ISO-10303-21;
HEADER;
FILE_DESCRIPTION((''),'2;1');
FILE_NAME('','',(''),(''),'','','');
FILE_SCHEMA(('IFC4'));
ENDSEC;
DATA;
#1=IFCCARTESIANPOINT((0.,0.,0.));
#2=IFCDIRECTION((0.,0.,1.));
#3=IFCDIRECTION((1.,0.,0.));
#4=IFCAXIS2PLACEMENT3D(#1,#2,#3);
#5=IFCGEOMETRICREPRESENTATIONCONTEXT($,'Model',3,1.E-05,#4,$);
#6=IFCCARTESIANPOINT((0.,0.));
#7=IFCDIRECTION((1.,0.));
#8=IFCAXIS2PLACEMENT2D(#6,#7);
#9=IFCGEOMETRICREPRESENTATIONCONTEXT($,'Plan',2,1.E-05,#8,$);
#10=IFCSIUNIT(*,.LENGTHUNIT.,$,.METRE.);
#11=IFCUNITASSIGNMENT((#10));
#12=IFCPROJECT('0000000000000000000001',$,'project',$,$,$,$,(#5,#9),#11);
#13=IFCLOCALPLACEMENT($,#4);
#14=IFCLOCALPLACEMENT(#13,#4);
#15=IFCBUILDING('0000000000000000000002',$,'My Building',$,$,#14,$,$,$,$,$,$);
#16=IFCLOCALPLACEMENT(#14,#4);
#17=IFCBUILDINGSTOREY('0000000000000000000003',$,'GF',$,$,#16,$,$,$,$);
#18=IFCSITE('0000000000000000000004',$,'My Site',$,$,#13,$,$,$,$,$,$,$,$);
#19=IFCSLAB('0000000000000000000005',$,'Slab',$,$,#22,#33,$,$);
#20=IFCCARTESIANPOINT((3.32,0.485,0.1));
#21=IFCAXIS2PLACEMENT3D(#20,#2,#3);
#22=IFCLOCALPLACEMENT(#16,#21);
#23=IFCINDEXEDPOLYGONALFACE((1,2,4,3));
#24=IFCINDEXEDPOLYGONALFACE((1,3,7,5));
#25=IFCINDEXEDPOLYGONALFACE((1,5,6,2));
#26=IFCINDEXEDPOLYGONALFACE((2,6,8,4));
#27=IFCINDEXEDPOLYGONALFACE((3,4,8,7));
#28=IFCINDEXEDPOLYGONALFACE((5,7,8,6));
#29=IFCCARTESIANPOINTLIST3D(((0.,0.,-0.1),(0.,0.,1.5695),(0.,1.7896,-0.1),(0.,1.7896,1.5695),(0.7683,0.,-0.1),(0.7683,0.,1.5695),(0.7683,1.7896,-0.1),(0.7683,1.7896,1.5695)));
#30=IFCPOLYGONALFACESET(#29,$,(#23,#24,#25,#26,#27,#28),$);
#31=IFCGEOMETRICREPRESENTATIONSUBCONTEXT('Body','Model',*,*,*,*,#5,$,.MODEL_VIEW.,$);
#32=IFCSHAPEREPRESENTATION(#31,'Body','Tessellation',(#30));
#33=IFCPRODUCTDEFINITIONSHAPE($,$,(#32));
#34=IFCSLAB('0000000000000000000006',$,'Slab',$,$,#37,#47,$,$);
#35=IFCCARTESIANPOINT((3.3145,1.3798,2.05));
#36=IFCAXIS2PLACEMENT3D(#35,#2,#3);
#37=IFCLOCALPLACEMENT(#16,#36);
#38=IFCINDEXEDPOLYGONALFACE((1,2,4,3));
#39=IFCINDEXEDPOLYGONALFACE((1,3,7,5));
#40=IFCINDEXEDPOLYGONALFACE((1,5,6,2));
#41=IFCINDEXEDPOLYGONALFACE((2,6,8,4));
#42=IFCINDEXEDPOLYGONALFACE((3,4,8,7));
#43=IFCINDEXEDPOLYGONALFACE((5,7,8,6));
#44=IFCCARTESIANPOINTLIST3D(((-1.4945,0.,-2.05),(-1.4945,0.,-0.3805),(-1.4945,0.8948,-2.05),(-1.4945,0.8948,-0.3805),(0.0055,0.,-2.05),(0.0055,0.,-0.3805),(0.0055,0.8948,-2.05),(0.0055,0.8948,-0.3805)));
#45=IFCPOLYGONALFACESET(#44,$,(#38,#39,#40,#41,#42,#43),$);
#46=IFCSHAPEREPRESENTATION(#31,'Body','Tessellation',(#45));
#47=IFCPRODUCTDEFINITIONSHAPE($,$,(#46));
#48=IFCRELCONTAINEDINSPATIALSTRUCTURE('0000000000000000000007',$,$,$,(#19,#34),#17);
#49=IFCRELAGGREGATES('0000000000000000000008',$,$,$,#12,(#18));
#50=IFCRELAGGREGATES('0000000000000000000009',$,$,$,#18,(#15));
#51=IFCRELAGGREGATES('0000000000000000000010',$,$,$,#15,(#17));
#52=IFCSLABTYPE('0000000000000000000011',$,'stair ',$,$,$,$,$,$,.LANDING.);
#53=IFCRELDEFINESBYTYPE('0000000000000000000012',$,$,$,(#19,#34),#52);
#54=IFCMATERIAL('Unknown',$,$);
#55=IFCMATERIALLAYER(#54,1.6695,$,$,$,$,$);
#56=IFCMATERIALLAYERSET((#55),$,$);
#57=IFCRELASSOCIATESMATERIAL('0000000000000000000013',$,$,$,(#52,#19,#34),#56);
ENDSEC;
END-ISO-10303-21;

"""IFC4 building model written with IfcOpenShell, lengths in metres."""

from ifc_helpers import new_model, si_unit, frame, origin_with_axes, origin_2d_with_axis, place, context, subcontext, project, spatial, indexed_curve, outline, extrude, material, layer, layer_set, layer_usage, type_object, element, save


model = new_model("IFC4")

# Units and contexts
model_context = context("Model", 3, precision=1e-05, world=origin_with_axes())
plan_context = context("Plan", 2, precision=1e-05, world=origin_2d_with_axis())
body_context_1 = subcontext(model_context, "Body", "Model", "MODEL_VIEW")
ifc_project = project(units=[si_unit("LENGTHUNIT", "METRE")], contexts=[model_context, plan_context])

# Site, building, storey
site_placement = place(None, origin_with_axes())
site = spatial("IfcSite", under=ifc_project, at=site_placement, Name="My Site")
building_placement = place(site_placement, origin_with_axes())
building = spatial("IfcBuilding", under=site, at=building_placement, Name="My Building")
storey_placement = place(building_placement, origin_with_axes())
storey = spatial("IfcBuildingStorey", under=building, at=storey_placement, Name="GF")

# Slabs
ifc_material = material(Name="Unknown")
ifc_layer_1 = layer(ifc_material, 1.6695)
ifc_layer_set_1 = layer_set([ifc_layer_1])
ifc_layer_usage_1 = layer_usage(ifc_layer_set_1, "AXIS3", "POSITIVE", -0.1)
slab_type_1 = type_object("IfcSlabType", Name="stair ", PredefinedType="LANDING", material=ifc_layer_set_1)
slab_1_placement = place(storey_placement, frame((3.32, 0.485, 0.1), z_axis=(0.0, 0.0, 1.0), x_axis=(1.0, 0.0, 0.0)))
element("IfcSlab", 1, at=slab_1_placement, inside=storey, type_object=slab_type_1, material=ifc_layer_usage_1, Name="Slab", context=body_context_1, shape_type="SweptSolid", body=[
    extrude(outline(indexed_curve([(0.0, 0.0), (0.7683, 0.0), (0.7683, 1.7896), (0.0, 1.7896), (0.0, 0.0)])), frame((0.0, 0.0, -0.1), z_axis=(0.0, 0.0, 1.0), x_axis=(1.0, 0.0, 0.0)), (0.0, 0.0, 1.0), 1.6695),
])
ifc_layer_usage_2 = layer_usage(ifc_layer_set_1, "AXIS3", "POSITIVE", -2.05)
slab_2_placement = place(storey_placement, frame((3.3145, 1.3798, 2.05), z_axis=(0.0, 0.0, 1.0), x_axis=(1.0, 0.0, 0.0)))
element("IfcSlab", 2, at=slab_2_placement, inside=storey, type_object=slab_type_1, material=ifc_layer_usage_2, Name="Slab", context=body_context_1, shape_type="SweptSolid", body=[
    extrude(outline(indexed_curve([(-1.4945, 0.0), (-1.4945, 0.8948), (0.0055, 0.8948), (0.0055, 0.0), (-1.4945, 0.0)])), frame((0.0, 0.0, -2.05), z_axis=(0.0, 0.0, 1.0), x_axis=(1.0, 0.0, 0.0)), (0.0, 0.0, 1.0), 1.6695),
])

save(model, "model.ifc")
